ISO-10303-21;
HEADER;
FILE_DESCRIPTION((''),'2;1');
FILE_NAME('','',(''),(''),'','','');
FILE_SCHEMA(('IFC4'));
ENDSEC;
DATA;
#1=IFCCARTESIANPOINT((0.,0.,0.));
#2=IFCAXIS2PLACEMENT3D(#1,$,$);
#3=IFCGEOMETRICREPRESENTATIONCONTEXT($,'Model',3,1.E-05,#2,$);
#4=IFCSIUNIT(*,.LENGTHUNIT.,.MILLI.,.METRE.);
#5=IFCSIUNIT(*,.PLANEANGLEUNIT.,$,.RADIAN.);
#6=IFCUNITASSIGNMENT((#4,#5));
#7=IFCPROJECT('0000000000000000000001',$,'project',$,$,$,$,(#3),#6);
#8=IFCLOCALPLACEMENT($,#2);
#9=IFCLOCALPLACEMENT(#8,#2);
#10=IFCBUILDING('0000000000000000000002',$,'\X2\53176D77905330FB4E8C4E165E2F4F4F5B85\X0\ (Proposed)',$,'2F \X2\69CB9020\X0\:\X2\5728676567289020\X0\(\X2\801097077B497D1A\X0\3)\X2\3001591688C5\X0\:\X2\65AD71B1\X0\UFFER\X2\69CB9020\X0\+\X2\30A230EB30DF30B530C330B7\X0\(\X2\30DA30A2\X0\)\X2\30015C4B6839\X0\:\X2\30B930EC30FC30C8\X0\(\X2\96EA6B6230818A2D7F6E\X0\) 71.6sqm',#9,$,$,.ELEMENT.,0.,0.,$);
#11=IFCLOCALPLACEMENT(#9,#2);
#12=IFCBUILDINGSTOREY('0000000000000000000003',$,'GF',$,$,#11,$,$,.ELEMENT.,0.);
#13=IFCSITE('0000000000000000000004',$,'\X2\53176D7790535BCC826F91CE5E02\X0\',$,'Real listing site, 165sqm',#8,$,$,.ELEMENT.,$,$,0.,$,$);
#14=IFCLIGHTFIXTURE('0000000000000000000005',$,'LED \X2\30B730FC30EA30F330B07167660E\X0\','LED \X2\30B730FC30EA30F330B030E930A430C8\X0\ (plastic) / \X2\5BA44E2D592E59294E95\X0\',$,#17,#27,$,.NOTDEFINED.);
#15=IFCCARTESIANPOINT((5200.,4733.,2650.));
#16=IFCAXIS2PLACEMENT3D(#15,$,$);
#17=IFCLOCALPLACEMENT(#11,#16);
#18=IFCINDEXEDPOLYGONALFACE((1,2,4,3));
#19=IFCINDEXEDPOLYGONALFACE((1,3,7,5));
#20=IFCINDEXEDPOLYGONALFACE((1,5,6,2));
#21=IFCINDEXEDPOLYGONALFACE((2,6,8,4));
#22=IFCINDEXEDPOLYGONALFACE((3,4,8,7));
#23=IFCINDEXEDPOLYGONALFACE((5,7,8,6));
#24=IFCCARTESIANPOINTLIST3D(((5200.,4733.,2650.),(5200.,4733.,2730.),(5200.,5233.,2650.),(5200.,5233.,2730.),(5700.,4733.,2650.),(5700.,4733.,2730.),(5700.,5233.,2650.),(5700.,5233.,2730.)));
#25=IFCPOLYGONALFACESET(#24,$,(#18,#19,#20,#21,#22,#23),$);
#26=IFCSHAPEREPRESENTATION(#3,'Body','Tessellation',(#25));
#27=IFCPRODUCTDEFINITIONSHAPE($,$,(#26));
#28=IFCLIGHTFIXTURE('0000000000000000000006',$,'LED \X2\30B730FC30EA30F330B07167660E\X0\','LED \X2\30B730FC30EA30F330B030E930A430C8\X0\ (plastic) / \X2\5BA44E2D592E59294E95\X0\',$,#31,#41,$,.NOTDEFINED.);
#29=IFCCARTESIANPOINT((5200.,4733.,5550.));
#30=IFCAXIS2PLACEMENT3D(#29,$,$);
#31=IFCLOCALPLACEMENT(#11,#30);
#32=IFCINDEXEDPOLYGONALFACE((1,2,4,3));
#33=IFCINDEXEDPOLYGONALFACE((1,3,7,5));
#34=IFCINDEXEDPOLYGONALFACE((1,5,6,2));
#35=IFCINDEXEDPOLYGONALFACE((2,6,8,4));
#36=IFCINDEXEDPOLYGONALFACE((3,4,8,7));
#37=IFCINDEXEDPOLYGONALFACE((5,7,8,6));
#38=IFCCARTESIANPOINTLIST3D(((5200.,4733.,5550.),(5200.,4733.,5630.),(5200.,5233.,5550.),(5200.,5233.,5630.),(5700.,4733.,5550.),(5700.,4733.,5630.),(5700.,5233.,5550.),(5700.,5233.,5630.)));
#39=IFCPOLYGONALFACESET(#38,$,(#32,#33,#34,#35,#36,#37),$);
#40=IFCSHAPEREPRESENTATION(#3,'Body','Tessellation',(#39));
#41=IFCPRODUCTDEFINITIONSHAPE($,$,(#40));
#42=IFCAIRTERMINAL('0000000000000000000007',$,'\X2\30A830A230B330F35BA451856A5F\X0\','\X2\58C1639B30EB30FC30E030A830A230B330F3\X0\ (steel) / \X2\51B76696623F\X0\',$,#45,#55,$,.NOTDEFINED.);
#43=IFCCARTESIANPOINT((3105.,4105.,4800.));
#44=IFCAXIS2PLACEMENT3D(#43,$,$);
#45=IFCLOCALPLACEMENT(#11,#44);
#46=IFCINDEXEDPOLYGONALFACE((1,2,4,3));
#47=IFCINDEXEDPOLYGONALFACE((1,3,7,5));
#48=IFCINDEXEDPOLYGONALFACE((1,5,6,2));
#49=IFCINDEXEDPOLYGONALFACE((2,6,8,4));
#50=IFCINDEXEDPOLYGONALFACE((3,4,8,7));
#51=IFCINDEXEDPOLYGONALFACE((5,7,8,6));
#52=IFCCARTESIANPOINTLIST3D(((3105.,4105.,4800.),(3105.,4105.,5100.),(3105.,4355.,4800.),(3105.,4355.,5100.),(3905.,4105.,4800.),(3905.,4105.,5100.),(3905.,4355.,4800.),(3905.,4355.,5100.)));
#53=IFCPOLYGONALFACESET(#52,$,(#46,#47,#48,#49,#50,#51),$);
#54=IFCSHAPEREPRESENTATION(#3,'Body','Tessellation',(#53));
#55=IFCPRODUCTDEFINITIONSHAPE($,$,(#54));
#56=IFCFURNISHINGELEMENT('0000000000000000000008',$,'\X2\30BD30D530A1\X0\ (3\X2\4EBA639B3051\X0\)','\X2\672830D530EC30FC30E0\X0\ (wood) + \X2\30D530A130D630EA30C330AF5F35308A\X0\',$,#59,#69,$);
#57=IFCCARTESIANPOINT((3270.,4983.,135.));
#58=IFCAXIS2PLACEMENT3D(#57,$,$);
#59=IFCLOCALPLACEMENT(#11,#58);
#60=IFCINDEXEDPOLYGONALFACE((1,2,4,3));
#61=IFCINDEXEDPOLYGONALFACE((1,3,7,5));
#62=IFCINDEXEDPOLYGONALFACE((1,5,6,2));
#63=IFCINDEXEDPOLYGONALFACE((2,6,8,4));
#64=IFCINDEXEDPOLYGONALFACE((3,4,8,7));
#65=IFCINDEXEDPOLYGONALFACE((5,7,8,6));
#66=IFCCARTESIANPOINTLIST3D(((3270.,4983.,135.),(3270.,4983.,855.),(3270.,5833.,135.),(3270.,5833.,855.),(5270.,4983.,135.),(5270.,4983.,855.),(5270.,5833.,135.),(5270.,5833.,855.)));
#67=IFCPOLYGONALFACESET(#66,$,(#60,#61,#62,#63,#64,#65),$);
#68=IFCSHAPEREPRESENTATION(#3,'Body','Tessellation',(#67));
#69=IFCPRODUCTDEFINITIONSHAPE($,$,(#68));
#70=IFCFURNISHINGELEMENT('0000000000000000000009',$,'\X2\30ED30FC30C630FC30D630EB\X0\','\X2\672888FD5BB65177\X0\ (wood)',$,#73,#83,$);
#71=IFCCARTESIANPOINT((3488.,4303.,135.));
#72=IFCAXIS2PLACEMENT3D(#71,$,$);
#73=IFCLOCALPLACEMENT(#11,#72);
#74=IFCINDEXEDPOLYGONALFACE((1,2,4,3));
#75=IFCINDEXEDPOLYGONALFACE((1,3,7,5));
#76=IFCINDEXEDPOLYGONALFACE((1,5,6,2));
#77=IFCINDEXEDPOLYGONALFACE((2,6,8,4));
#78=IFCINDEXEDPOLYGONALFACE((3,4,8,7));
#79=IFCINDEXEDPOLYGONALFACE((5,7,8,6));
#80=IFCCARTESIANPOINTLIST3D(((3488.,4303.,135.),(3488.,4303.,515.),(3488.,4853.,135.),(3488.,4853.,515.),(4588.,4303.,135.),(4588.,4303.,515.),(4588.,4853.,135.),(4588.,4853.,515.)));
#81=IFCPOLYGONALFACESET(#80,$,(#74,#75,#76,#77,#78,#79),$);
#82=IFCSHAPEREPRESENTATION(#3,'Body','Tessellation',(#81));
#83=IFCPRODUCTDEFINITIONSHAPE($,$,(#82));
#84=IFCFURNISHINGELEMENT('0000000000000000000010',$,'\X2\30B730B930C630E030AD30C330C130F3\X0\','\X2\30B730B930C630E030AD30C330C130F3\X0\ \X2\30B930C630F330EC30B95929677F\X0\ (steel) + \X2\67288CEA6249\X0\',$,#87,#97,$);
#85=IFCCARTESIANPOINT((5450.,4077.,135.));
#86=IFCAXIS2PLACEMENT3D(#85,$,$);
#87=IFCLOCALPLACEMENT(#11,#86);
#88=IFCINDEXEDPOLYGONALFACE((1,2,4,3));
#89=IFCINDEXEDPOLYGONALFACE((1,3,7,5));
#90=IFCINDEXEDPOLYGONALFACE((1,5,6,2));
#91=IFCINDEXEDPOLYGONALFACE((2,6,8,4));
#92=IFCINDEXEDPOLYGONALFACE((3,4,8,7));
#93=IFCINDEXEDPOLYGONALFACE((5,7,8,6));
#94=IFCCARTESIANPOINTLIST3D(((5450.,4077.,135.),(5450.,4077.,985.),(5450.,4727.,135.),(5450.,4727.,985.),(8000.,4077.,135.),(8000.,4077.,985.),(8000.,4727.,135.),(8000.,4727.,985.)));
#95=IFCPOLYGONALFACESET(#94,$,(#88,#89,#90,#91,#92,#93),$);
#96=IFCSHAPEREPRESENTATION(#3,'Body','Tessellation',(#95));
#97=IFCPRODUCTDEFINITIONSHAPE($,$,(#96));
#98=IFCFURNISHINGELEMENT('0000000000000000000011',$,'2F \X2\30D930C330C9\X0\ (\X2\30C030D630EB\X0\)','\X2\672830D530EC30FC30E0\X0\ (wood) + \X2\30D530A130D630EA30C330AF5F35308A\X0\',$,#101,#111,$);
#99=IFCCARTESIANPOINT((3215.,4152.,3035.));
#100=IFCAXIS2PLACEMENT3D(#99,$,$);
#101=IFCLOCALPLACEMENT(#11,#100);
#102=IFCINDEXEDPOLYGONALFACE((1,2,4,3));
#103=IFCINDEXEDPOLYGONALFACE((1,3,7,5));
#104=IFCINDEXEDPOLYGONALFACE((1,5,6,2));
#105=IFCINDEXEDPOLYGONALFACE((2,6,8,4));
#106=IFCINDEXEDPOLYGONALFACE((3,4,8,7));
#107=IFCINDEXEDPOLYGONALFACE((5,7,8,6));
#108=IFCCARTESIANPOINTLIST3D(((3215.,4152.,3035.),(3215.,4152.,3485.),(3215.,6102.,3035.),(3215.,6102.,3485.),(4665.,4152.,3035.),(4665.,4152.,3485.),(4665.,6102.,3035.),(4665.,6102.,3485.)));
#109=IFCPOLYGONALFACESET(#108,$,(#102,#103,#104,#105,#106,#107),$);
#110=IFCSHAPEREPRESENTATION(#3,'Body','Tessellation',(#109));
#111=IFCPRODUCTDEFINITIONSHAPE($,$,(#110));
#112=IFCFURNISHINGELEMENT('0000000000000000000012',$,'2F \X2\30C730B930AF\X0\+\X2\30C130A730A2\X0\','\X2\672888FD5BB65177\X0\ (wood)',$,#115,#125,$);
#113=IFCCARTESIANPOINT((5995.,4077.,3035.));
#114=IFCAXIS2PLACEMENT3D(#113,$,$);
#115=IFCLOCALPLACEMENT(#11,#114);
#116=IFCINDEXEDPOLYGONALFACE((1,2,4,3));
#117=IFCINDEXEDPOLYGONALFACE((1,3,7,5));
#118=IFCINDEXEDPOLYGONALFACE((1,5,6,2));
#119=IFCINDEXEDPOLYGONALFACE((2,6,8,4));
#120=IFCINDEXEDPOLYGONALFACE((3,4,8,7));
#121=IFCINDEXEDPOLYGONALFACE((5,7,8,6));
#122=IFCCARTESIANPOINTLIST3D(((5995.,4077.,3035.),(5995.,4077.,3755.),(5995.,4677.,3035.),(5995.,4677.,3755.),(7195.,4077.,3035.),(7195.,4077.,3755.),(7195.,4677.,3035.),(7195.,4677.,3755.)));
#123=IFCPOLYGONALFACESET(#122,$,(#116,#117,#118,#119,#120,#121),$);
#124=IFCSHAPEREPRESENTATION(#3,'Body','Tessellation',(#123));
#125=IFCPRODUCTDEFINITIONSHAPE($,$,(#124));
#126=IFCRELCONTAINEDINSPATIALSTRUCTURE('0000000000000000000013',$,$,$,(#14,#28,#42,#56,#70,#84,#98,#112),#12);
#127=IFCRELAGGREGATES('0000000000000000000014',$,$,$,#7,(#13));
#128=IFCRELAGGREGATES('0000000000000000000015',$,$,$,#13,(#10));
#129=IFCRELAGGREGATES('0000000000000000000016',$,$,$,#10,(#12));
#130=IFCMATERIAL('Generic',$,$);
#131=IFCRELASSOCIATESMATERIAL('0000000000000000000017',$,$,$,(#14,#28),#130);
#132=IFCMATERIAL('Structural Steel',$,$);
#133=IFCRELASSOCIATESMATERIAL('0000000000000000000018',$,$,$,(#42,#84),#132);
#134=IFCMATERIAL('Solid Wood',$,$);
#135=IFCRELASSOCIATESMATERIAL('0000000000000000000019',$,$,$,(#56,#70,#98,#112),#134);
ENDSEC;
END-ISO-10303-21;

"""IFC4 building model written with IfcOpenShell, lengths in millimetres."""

from ifc_helpers import new_model, si_unit, frame, frame_2d, origin, place, context, project, spatial, rectangle, extrude, material, element, save


model = new_model("IFC4")

# Units and contexts
model_context = context("Model", 3, precision=1e-05, world=origin())
ifc_project = project(units=[si_unit("LENGTHUNIT", "METRE", prefix="MILLI"), si_unit("PLANEANGLEUNIT", "RADIAN")], contexts=[model_context])

# Site, building, storey
site_placement = place(None, origin())
site = spatial("IfcSite", under=ifc_project, at=site_placement, Name="北海道富良野市", ObjectType="Real listing site, 165sqm", CompositionType="ELEMENT", RefElevation=0.0)
building_placement = place(site_placement, origin())
building = spatial("IfcBuilding", under=site, at=building_placement, Name="北海道・二世帯住宅 (Proposed)", ObjectType="2F 構造:在来木造(耐震等級3)、外装:断熱UFFER構造+アルミサッシ(ペア)、屋根:スレート(雪止め設置) 71.6sqm", CompositionType="ELEMENT", ElevationOfRefHeight=0.0, ElevationOfTerrain=0.0)
storey_placement = place(building_placement, origin())
storey = spatial("IfcBuildingStorey", under=building, at=storey_placement, Name="GF", CompositionType="ELEMENT", Elevation=0.0)

# Shared definitions
ifc_material_1 = material(Name="Solid Wood")

# Shared definitions
ifc_material_2 = material(Name="Generic")

# Shared definitions
ifc_material_3 = material(Name="Structural Steel")

# Light fixtures
light_fixture_1_placement = place(storey_placement, frame((5200.0, 4733.0, 2650.0)))
element("IfcLightFixture", 1, at=light_fixture_1_placement, inside=storey, material=ifc_material_2, Name="LED シーリング照明", Description="LED シーリングライト (plastic) / 室中央天井", PredefinedType="NOTDEFINED", context=model_context, shape_type="SweptSolid", body=[
    extrude(rectangle(XDim=500.0, YDim=500.0, at=frame_2d((250.0, 250.0))), frame((5200.0, 4733.0, 2650.0)), (0.0, 0.0, 1.0), 80.0),
])
light_fixture_2_placement = place(storey_placement, frame((5200.0, 4733.0, 5550.0)))
element("IfcLightFixture", 2, at=light_fixture_2_placement, inside=storey, material=ifc_material_2, Name="LED シーリング照明", Description="LED シーリングライト (plastic) / 室中央天井", PredefinedType="NOTDEFINED", context=model_context, shape_type="SweptSolid", body=[
    extrude(rectangle(XDim=500.0, YDim=500.0, at=frame_2d((250.0, 250.0))), frame((5200.0, 4733.0, 5550.0)), (0.0, 0.0, 1.0), 80.0),
])

# Air terminal
air_terminal_placement = place(storey_placement, frame((3105.0, 4105.0, 4800.0)))
element("IfcAirTerminal", 3, at=air_terminal_placement, inside=storey, material=ifc_material_3, Name="エアコン室内機", Description="壁掛ルームエアコン (steel) / 冷暖房", PredefinedType="NOTDEFINED", context=model_context, shape_type="SweptSolid", body=[
    extrude(rectangle(XDim=800.0, YDim=250.0, at=frame_2d((400.0, 125.0))), frame((3105.0, 4105.0, 4800.0)), (0.0, 0.0, 1.0), 300.0),
])

# Furnishing elements
furnishing_1_placement = place(storey_placement, frame((3270.0, 4983.0, 135.0)))
element("IfcFurnishingElement", 4, at=furnishing_1_placement, inside=storey, material=ifc_material_1, Name="ソファ (3人掛け)", Description="木フレーム (wood) + ファブリック張り", context=model_context, shape_type="SweptSolid", body=[
    extrude(rectangle(XDim=2000.0, YDim=850.0, at=frame_2d((1000.0, 425.0))), frame((3270.0, 4983.0, 135.0)), (0.0, 0.0, 1.0), 720.0),
])
furnishing_2_placement = place(storey_placement, frame((3488.0, 4303.0, 135.0)))
element("IfcFurnishingElement", 5, at=furnishing_2_placement, inside=storey, material=ifc_material_1, Name="ローテーブル", Description="木製家具 (wood)", context=model_context, shape_type="SweptSolid", body=[
    extrude(rectangle(XDim=1100.0, YDim=550.0, at=frame_2d((550.0, 275.0))), frame((3488.0, 4303.0, 135.0)), (0.0, 0.0, 1.0), 380.0),
])
furnishing_3_placement = place(storey_placement, frame((5450.0, 4077.0, 135.0)))
element("IfcFurnishingElement", 6, at=furnishing_3_placement, inside=storey, material=ifc_material_3, Name="システムキッチン", Description="システムキッチン ステンレス天板 (steel) + 木質扉", context=model_context, shape_type="SweptSolid", body=[
    extrude(rectangle(XDim=2550.0, YDim=650.0, at=frame_2d((1275.0, 325.0))), frame((5450.0, 4077.0, 135.0)), (0.0, 0.0, 1.0), 850.0),
])
furnishing_4_placement = place(storey_placement, frame((3215.0, 4152.0, 3035.0)))
element("IfcFurnishingElement", 7, at=furnishing_4_placement, inside=storey, material=ifc_material_1, Name="2F ベッド (ダブル)", Description="木フレーム (wood) + ファブリック張り", context=model_context, shape_type="SweptSolid", body=[
    extrude(rectangle(XDim=1450.0, YDim=1950.0, at=frame_2d((725.0, 975.0))), frame((3215.0, 4152.0, 3035.0)), (0.0, 0.0, 1.0), 450.0),
])
furnishing_5_placement = place(storey_placement, frame((5995.0, 4077.0, 3035.0)))
element("IfcFurnishingElement", 8, at=furnishing_5_placement, inside=storey, material=ifc_material_1, Name="2F デスク+チェア", Description="木製家具 (wood)", context=model_context, shape_type="SweptSolid", body=[
    extrude(rectangle(XDim=1200.0, YDim=600.0, at=frame_2d((600.0, 300.0))), frame((5995.0, 4077.0, 3035.0)), (0.0, 0.0, 1.0), 720.0),
])

save(model, "model.ifc")
